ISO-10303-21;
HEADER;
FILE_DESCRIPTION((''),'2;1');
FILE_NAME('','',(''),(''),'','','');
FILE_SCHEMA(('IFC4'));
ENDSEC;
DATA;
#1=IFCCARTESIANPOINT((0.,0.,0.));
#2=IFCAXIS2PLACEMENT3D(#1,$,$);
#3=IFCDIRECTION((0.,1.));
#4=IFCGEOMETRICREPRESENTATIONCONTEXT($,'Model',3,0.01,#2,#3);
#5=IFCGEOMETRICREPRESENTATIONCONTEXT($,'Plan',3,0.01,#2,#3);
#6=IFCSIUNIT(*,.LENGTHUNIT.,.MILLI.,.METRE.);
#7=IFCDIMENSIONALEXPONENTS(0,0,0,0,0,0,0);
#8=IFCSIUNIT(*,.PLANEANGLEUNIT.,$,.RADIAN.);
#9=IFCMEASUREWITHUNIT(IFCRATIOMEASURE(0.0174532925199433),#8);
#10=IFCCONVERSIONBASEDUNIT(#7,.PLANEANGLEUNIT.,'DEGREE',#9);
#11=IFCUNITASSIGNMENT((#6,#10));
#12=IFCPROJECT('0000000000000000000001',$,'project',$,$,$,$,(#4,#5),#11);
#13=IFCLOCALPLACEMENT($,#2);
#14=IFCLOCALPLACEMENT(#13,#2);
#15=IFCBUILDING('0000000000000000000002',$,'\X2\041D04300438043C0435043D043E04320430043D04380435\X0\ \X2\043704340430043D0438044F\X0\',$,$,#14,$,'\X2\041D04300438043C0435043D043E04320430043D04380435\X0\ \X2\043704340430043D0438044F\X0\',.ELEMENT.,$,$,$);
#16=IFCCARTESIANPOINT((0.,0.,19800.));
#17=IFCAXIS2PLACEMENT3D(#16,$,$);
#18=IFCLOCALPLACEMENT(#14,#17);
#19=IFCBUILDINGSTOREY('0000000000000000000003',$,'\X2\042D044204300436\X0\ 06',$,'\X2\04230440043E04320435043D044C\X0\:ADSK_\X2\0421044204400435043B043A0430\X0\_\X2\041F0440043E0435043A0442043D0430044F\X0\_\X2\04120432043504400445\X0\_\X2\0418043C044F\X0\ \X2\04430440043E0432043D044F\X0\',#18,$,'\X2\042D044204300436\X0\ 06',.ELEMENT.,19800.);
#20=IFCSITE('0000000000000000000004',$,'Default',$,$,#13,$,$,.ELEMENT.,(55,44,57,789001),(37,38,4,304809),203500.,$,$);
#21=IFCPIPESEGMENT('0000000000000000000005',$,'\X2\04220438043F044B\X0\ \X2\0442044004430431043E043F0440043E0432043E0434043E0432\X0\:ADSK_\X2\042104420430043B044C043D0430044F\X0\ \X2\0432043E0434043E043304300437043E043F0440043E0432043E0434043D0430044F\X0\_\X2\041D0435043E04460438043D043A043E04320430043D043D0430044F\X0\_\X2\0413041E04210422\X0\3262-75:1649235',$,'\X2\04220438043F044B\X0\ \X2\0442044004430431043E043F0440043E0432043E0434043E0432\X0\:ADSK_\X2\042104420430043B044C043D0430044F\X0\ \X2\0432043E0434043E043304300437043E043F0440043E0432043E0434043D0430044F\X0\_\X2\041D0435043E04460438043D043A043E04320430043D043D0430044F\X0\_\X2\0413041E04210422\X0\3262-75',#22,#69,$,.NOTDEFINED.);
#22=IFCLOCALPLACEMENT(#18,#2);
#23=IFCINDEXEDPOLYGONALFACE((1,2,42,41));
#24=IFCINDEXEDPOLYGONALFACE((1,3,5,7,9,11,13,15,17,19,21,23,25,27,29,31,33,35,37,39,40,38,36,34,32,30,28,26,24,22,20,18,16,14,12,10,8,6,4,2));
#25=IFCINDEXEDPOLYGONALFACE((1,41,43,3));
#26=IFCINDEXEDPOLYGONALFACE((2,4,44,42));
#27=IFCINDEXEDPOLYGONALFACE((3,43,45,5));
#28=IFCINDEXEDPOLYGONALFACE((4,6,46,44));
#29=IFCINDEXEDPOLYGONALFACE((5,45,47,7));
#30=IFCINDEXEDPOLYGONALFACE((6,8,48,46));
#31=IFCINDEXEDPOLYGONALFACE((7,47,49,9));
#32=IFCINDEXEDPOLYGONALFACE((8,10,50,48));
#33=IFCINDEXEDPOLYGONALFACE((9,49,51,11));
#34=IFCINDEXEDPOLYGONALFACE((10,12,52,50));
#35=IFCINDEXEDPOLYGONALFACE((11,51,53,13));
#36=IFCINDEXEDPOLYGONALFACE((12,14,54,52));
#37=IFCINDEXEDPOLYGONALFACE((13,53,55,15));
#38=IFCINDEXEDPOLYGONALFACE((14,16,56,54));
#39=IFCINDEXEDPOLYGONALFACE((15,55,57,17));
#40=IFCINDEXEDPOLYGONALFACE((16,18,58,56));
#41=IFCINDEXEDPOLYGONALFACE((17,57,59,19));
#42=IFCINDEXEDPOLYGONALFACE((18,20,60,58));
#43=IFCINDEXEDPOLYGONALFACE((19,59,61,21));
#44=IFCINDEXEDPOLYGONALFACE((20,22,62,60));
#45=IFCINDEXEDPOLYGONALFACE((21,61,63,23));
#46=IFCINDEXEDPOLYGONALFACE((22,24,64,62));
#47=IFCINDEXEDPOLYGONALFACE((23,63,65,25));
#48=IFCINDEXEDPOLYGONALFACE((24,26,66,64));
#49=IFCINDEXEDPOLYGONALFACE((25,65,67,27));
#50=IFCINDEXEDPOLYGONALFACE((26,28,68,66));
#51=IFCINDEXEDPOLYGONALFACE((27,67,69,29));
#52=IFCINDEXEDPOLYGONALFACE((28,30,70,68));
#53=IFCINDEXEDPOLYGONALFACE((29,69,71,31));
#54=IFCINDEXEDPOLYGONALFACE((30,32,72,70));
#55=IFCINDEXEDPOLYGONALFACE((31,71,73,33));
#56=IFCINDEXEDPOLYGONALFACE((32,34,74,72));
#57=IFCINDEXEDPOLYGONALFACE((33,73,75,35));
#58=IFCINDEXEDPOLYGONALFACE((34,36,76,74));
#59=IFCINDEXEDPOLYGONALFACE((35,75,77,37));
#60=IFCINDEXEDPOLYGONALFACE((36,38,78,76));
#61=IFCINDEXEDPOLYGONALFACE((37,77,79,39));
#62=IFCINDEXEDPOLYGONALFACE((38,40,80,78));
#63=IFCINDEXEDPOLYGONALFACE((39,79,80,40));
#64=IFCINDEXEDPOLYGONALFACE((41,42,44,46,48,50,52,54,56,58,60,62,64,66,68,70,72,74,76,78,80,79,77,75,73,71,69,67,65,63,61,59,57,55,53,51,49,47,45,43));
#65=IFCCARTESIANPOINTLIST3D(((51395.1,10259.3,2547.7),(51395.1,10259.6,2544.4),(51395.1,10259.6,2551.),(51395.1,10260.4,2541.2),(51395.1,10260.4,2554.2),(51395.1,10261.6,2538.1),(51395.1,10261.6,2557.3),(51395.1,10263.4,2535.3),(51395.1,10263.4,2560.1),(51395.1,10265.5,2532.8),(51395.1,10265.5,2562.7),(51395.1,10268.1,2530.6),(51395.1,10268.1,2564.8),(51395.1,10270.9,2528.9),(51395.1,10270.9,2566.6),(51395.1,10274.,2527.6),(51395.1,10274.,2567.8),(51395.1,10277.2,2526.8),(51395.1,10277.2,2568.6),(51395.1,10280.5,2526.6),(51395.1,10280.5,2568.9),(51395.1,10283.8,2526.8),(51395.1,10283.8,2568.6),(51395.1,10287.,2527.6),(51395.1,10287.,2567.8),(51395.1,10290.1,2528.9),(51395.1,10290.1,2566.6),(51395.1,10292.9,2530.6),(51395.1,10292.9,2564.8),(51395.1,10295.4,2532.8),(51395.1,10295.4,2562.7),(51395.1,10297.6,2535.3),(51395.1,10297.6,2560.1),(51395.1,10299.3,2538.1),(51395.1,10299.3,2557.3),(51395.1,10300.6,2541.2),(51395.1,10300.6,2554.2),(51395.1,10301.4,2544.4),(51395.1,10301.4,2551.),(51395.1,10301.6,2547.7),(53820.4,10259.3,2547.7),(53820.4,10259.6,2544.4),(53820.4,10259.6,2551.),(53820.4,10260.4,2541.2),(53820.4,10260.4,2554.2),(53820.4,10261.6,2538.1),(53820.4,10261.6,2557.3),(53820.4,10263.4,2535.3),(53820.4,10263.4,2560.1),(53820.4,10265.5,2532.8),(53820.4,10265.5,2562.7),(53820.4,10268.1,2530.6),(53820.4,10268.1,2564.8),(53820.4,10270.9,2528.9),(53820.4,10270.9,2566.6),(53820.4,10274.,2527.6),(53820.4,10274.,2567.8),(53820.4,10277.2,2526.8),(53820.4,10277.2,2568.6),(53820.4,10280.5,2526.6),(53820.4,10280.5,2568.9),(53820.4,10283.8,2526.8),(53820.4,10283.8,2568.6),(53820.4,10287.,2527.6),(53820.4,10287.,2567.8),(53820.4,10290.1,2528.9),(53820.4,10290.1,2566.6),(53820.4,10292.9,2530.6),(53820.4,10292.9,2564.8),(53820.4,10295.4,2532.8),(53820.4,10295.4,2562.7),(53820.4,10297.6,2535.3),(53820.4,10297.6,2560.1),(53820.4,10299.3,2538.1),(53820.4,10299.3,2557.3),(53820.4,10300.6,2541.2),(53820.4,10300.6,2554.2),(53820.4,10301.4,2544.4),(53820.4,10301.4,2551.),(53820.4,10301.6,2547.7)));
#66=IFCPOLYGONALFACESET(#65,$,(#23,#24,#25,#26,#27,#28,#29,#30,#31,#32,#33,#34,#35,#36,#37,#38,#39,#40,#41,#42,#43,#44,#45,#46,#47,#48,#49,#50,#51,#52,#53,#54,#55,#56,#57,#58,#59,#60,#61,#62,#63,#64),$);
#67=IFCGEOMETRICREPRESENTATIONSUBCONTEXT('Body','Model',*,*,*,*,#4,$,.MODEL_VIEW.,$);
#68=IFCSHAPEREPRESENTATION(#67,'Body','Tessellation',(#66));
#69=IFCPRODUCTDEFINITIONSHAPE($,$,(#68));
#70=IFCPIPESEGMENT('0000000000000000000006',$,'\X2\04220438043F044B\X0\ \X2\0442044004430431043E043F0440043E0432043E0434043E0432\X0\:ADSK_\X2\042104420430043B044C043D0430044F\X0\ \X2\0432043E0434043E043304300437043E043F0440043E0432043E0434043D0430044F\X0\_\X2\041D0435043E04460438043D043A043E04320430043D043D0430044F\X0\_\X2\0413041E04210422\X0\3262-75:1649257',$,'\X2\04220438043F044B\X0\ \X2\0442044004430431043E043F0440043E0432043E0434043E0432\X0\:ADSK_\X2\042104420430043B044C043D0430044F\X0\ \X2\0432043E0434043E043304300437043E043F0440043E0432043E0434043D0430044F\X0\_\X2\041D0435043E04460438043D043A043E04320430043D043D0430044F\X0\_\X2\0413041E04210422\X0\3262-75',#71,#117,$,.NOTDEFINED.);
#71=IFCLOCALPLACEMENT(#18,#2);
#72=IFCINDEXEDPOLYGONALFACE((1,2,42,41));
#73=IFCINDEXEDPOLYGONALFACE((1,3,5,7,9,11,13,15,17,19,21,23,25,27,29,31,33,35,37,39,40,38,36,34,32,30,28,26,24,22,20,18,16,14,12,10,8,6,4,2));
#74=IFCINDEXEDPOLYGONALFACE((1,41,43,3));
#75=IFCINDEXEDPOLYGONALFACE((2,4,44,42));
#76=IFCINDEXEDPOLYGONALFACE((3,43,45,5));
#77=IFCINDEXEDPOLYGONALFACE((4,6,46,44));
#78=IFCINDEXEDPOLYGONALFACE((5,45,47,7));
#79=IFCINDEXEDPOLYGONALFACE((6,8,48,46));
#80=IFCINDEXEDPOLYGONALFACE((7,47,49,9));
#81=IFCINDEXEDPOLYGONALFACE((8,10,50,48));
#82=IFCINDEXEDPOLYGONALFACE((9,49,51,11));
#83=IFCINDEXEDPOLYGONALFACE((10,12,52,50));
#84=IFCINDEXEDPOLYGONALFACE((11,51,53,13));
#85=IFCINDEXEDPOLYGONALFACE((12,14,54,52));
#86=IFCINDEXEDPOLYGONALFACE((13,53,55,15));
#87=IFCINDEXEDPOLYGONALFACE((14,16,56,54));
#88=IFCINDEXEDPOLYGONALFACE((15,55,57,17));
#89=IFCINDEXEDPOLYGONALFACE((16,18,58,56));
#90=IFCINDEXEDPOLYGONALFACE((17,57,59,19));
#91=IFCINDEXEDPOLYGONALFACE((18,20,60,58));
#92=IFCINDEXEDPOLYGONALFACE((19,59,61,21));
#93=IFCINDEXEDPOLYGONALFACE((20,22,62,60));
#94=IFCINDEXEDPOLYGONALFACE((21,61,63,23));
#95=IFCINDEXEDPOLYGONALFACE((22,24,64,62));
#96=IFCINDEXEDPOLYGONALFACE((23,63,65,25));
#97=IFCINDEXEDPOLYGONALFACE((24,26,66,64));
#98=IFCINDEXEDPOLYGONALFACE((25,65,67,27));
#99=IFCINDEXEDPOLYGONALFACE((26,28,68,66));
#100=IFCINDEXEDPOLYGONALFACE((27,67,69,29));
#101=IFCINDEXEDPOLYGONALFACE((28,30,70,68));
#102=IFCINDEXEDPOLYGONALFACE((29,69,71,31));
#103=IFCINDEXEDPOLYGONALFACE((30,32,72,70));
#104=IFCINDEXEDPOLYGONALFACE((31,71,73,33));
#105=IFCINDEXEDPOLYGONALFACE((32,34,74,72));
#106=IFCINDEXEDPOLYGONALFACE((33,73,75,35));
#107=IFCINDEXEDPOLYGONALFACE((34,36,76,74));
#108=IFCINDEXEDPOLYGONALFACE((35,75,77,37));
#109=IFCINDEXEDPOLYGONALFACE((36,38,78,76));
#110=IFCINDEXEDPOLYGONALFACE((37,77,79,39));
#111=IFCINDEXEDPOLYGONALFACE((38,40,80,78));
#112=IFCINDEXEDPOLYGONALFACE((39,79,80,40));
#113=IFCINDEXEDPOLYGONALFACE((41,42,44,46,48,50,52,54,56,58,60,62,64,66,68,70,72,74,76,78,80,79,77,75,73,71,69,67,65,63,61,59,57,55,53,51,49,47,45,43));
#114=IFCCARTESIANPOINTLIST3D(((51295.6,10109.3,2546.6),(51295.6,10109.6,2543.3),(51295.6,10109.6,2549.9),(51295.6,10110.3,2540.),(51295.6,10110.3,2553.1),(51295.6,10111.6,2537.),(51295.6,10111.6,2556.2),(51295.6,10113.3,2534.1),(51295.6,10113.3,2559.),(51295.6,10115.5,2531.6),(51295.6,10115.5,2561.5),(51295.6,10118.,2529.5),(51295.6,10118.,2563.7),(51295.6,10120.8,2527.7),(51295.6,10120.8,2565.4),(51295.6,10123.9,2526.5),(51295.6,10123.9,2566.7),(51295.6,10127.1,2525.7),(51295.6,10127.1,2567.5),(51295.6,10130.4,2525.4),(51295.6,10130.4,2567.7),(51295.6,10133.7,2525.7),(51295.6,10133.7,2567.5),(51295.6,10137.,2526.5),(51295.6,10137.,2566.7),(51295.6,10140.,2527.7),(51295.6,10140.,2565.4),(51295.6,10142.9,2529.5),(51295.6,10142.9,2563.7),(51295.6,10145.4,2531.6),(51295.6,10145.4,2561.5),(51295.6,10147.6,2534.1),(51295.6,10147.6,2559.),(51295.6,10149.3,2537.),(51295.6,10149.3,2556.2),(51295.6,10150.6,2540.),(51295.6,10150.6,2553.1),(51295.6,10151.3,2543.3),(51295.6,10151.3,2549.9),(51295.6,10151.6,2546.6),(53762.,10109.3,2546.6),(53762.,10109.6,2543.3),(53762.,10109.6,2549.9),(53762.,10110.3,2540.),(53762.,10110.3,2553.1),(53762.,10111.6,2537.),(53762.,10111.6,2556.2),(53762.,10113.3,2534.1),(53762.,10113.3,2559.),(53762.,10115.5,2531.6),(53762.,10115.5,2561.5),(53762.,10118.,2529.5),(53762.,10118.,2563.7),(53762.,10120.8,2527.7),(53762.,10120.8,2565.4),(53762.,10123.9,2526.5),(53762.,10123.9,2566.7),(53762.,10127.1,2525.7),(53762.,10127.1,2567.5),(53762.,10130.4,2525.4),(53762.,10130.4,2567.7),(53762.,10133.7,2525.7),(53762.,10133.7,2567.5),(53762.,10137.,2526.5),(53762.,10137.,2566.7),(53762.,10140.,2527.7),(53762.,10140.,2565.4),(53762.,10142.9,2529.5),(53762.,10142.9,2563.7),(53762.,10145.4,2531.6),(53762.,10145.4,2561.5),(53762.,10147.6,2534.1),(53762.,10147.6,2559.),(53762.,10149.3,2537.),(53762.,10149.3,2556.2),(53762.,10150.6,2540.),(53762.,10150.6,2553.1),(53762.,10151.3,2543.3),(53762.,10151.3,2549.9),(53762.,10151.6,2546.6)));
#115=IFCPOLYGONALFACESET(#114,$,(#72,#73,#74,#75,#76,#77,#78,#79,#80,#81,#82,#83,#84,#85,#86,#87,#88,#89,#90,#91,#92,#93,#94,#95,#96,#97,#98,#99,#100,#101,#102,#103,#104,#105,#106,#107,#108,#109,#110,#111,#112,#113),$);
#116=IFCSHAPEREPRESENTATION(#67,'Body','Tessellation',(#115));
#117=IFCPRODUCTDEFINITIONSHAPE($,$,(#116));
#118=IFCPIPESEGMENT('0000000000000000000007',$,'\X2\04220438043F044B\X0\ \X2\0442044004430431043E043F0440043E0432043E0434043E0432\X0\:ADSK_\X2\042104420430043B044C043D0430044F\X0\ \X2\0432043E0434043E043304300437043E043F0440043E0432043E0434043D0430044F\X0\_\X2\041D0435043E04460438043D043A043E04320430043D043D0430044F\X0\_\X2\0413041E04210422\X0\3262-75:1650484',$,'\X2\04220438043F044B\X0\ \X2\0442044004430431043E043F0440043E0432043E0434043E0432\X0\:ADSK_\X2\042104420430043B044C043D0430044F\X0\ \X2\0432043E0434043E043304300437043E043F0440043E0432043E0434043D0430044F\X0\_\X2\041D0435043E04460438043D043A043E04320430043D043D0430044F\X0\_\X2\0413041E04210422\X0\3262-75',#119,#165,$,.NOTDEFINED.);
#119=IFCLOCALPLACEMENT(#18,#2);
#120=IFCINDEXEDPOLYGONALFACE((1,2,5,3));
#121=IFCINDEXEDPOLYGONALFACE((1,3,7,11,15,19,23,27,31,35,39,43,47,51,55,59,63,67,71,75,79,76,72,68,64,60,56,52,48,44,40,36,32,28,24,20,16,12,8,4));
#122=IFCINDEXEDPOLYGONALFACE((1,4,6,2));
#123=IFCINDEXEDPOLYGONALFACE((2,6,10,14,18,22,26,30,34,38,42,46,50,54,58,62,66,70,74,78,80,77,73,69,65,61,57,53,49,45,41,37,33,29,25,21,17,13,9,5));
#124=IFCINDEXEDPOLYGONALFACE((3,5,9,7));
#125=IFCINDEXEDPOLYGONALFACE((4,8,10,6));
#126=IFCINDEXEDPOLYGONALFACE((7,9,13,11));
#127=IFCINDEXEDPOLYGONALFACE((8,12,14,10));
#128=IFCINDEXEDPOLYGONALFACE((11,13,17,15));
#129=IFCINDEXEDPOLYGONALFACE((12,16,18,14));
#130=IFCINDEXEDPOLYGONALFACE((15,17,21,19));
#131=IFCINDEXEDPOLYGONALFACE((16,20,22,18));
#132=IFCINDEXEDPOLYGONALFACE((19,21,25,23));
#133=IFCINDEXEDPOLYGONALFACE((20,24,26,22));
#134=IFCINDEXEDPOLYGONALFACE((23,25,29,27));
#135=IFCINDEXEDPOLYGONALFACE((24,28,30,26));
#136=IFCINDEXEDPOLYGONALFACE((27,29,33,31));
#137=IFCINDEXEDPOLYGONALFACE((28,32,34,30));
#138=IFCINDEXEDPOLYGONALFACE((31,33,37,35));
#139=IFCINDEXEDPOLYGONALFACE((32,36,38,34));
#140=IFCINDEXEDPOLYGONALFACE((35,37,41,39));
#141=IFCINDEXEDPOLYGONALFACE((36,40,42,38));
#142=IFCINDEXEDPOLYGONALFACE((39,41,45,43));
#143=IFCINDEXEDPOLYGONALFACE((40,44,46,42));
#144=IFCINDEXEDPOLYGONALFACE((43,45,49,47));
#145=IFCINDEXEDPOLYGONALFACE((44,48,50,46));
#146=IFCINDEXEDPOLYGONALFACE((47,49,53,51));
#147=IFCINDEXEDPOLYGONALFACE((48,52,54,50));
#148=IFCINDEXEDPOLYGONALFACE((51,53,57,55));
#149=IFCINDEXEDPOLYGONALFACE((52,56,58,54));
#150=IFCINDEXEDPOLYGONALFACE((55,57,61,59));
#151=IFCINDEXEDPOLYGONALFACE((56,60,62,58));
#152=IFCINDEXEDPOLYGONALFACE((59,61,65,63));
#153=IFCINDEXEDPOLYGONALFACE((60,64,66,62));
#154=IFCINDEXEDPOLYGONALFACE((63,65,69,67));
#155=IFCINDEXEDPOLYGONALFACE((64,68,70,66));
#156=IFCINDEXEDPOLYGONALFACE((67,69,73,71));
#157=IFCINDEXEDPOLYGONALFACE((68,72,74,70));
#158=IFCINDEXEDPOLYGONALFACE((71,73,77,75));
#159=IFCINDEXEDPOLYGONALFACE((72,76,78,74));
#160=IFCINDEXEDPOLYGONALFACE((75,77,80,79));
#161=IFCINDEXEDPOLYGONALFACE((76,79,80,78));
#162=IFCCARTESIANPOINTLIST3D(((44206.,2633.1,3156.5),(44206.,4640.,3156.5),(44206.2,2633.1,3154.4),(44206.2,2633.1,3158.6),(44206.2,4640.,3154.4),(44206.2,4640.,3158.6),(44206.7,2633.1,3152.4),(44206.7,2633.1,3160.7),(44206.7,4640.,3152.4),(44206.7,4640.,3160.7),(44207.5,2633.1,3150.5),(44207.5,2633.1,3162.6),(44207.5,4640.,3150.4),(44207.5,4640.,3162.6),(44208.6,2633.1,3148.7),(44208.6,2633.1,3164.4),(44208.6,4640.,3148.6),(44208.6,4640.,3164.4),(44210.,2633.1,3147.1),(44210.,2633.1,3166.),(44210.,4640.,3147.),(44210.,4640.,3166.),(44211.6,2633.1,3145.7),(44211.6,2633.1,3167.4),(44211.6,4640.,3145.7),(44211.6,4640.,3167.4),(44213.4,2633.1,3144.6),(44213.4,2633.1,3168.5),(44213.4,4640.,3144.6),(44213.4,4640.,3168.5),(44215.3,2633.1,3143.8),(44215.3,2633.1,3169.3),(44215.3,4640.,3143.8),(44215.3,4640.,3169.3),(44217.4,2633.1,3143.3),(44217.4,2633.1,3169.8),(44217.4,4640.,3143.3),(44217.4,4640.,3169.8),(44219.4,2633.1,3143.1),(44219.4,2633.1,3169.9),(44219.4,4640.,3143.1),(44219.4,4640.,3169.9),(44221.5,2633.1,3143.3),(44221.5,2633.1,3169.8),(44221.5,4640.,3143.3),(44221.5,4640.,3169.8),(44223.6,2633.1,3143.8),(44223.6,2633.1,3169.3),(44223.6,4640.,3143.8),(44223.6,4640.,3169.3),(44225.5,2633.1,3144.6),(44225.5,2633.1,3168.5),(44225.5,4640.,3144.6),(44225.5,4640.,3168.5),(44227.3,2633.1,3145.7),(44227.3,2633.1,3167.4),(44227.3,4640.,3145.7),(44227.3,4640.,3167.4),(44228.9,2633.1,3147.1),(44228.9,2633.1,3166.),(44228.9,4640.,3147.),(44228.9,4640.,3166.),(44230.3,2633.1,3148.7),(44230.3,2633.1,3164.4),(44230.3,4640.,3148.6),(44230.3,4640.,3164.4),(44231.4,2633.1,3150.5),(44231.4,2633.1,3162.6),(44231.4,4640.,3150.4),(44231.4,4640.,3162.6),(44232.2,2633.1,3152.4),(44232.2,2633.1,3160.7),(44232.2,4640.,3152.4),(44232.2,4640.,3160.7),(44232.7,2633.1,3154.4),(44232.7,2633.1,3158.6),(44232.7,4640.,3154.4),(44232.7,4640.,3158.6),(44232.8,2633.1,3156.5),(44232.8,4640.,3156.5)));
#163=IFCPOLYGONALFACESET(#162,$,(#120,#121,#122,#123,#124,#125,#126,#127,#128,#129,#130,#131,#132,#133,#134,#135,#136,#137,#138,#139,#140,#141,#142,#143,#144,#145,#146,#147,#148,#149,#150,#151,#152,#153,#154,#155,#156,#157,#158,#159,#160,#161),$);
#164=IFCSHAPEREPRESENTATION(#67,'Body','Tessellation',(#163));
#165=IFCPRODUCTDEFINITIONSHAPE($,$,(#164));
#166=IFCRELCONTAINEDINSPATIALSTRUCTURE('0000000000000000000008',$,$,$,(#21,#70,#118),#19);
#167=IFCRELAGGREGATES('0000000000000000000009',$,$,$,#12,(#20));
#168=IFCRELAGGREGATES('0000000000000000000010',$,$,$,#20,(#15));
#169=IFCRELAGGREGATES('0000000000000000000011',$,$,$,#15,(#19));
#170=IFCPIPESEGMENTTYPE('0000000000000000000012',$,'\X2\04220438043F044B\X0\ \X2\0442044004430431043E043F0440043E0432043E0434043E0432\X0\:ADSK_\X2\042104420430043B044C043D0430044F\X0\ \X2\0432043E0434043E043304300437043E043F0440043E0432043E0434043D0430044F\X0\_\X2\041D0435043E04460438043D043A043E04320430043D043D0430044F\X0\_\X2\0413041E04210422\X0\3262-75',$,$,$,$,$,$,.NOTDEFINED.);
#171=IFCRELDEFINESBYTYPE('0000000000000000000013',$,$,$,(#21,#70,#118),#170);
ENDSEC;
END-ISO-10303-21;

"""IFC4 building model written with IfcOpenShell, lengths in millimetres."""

from ifc_helpers import new_model, entity, si_unit, converted_unit, direction, frame, origin, place, context, subcontext, project, spatial, indexed_curve, outline, extrude, type_object, element, save


model = new_model("IFC4")

# Units and contexts
model_context = context("Model", 3, precision=0.01, world=origin(), true_north=direction((0.0, 1.0)))
plan_context = context("Plan", 3, precision=0.01, world=origin(), true_north=direction((0.0, 1.0)))
body_context = subcontext(model_context, "Body", "Model", "MODEL_VIEW")
ifc_project = project(units=[si_unit("LENGTHUNIT", "METRE", prefix="MILLI"), converted_unit("PLANEANGLEUNIT", "DEGREE", entity("IfcRatioMeasure", 0.0174532925199433), si_unit("PLANEANGLEUNIT", "RADIAN"), dimensions=[0, 0, 0, 0, 0, 0, 0])], contexts=[model_context, plan_context])

# Site, building, storey
site_placement = place(None, origin())
site = spatial("IfcSite", under=ifc_project, at=site_placement, Name="Default", CompositionType="ELEMENT", RefLatitude=(55, 44, 57, 789001), RefLongitude=(37, 38, 4, 304809), RefElevation=203500.0)
building_placement = place(site_placement, origin())
building = spatial("IfcBuilding", under=site, at=building_placement, Name="Наименование здания", LongName="Наименование здания", CompositionType="ELEMENT")
storey_placement = place(building_placement, frame((0.0, 0.0, 19800.0)))
storey = spatial("IfcBuildingStorey", under=building, at=storey_placement, Name="Этаж 06", ObjectType="Уровень:ADSK_Стрелка_Проектная_Вверх_Имя уровня", LongName="Этаж 06", CompositionType="ELEMENT", Elevation=19800.0)

# Pipe segments
pipe_segment_type = type_object("IfcPipeSegmentType", Name="Типы трубопроводов:ADSK_Стальная водогазопроводная_Неоцинкованная_ГОСТ3262-75", PredefinedType="NOTDEFINED")
placement = place(storey_placement, origin())
element("IfcPipeSegment", 1, at=placement, inside=storey, type_object=pipe_segment_type, Name="Типы трубопроводов:ADSK_Стальная водогазопроводная_Неоцинкованная_ГОСТ3262-75:1649235", ObjectType="Типы трубопроводов:ADSK_Стальная водогазопроводная_Неоцинкованная_ГОСТ3262-75", PredefinedType="NOTDEFINED", context=body_context, shape_type="SweptSolid", body=[
    extrude(outline(indexed_curve([(21.1, 0.0), (20.9, 3.3), (20.1, 6.5), (18.8, 9.6), (17.1, 12.4), (15.0, 15.0), (12.4, 17.1), (9.6, 18.8), (6.5, 20.1), (3.3, 20.9), (0.0, 21.1), (-3.3, 20.9), (-6.5, 20.1), (-9.6, 18.8), (-12.4, 17.1), (-15.0, 15.0), (-17.1, 12.4), (-18.8, 9.6), (-20.1, 6.5), (-20.9, 3.3), (-21.1, 0.0), (-20.9, -3.3), (-20.1, -6.5), (-18.8, -9.6), (-17.1, -12.4), (-15.0, -15.0), (-12.4, -17.1), (-9.6, -18.8), (-6.5, -20.1), (-3.3, -20.9), (0.0, -21.1), (3.3, -20.9), (6.5, -20.1), (9.6, -18.8), (12.4, -17.1), (15.0, -15.0), (17.1, -12.4), (18.8, -9.6), (20.1, -6.5), (20.9, -3.3), (21.1, 0.0)], self_intersect=False)), frame((51395.1, 10280.5, 2547.7), z_axis=(1.0, 0.0, 0.0), x_axis=(0.0, 1.0, 0.0)), (0.0, 0.0, 1.0), 2425.3),
])
element("IfcPipeSegment", 2, at=placement, inside=storey, type_object=pipe_segment_type, Name="Типы трубопроводов:ADSK_Стальная водогазопроводная_Неоцинкованная_ГОСТ3262-75:1649257", ObjectType="Типы трубопроводов:ADSK_Стальная водогазопроводная_Неоцинкованная_ГОСТ3262-75", PredefinedType="NOTDEFINED", context=body_context, shape_type="SweptSolid", body=[
    extrude(outline(indexed_curve([(21.2, 0.0), (20.9, 3.3), (20.1, 6.5), (18.8, 9.6), (17.1, 12.4), (15.0, 15.0), (12.4, 17.1), (9.6, 18.8), (6.5, 20.1), (3.3, 20.9), (0.0, 21.2), (-3.3, 20.9), (-6.5, 20.1), (-9.6, 18.8), (-12.4, 17.1), (-15.0, 15.0), (-17.1, 12.4), (-18.8, 9.6), (-20.1, 6.5), (-20.9, 3.3), (-21.1, 0.0), (-20.9, -3.3), (-20.1, -6.5), (-18.8, -9.6), (-17.1, -12.4), (-15.0, -15.0), (-12.4, -17.1), (-9.6, -18.8), (-6.5, -20.1), (-3.3, -20.9), (0.0, -21.2), (3.3, -20.9), (6.5, -20.1), (9.6, -18.8), (12.4, -17.1), (15.0, -15.0), (17.1, -12.4), (18.8, -9.6), (20.1, -6.5), (20.9, -3.3), (21.2, 0.0)], self_intersect=False)), frame((51295.6, 10130.4, 2546.6), z_axis=(1.0, 0.0, 0.0), x_axis=(0.0, 1.0, 0.0)), (0.0, 0.0, 1.0), 2466.4),
])
element("IfcPipeSegment", 3, at=placement, inside=storey, type_object=pipe_segment_type, Name="Типы трубопроводов:ADSK_Стальная водогазопроводная_Неоцинкованная_ГОСТ3262-75:1650484", ObjectType="Типы трубопроводов:ADSK_Стальная водогазопроводная_Неоцинкованная_ГОСТ3262-75", PredefinedType="NOTDEFINED", context=body_context, shape_type="SweptSolid", body=[
    extrude(outline(indexed_curve([(13.4, 0.0), (13.2, 2.1), (12.7, 4.1), (11.9, 6.1), (10.8, 7.9), (9.5, 9.5), (7.9, 10.8), (6.1, 11.9), (4.1, 12.7), (2.1, 13.2), (0.0, 13.4), (-2.1, 13.2), (-4.1, 12.7), (-6.1, 11.9), (-7.9, 10.8), (-9.5, 9.5), (-10.8, 7.9), (-11.9, 6.1), (-12.7, 4.1), (-13.2, 2.1), (-13.4, 0.0), (-13.2, -2.1), (-12.7, -4.1), (-11.9, -6.1), (-10.8, -7.9), (-9.5, -9.5), (-7.9, -10.8), (-6.1, -11.9), (-4.1, -12.7), (-2.1, -13.2), (0.0, -13.4), (2.1, -13.2), (4.1, -12.7), (6.1, -11.9), (7.9, -10.8), (9.5, -9.5), (10.8, -7.9), (11.9, -6.1), (12.7, -4.1), (13.2, -2.1), (13.4, 0.0)], self_intersect=False)), frame((44219.4, 2633.1, 3156.5), z_axis=(0.0, 1.0, -0.000008), x_axis=(1.0, 0.0, 0.0)), (0.0, 0.0, 1.0), 2006.9),
])

save(model, "model.ifc")
